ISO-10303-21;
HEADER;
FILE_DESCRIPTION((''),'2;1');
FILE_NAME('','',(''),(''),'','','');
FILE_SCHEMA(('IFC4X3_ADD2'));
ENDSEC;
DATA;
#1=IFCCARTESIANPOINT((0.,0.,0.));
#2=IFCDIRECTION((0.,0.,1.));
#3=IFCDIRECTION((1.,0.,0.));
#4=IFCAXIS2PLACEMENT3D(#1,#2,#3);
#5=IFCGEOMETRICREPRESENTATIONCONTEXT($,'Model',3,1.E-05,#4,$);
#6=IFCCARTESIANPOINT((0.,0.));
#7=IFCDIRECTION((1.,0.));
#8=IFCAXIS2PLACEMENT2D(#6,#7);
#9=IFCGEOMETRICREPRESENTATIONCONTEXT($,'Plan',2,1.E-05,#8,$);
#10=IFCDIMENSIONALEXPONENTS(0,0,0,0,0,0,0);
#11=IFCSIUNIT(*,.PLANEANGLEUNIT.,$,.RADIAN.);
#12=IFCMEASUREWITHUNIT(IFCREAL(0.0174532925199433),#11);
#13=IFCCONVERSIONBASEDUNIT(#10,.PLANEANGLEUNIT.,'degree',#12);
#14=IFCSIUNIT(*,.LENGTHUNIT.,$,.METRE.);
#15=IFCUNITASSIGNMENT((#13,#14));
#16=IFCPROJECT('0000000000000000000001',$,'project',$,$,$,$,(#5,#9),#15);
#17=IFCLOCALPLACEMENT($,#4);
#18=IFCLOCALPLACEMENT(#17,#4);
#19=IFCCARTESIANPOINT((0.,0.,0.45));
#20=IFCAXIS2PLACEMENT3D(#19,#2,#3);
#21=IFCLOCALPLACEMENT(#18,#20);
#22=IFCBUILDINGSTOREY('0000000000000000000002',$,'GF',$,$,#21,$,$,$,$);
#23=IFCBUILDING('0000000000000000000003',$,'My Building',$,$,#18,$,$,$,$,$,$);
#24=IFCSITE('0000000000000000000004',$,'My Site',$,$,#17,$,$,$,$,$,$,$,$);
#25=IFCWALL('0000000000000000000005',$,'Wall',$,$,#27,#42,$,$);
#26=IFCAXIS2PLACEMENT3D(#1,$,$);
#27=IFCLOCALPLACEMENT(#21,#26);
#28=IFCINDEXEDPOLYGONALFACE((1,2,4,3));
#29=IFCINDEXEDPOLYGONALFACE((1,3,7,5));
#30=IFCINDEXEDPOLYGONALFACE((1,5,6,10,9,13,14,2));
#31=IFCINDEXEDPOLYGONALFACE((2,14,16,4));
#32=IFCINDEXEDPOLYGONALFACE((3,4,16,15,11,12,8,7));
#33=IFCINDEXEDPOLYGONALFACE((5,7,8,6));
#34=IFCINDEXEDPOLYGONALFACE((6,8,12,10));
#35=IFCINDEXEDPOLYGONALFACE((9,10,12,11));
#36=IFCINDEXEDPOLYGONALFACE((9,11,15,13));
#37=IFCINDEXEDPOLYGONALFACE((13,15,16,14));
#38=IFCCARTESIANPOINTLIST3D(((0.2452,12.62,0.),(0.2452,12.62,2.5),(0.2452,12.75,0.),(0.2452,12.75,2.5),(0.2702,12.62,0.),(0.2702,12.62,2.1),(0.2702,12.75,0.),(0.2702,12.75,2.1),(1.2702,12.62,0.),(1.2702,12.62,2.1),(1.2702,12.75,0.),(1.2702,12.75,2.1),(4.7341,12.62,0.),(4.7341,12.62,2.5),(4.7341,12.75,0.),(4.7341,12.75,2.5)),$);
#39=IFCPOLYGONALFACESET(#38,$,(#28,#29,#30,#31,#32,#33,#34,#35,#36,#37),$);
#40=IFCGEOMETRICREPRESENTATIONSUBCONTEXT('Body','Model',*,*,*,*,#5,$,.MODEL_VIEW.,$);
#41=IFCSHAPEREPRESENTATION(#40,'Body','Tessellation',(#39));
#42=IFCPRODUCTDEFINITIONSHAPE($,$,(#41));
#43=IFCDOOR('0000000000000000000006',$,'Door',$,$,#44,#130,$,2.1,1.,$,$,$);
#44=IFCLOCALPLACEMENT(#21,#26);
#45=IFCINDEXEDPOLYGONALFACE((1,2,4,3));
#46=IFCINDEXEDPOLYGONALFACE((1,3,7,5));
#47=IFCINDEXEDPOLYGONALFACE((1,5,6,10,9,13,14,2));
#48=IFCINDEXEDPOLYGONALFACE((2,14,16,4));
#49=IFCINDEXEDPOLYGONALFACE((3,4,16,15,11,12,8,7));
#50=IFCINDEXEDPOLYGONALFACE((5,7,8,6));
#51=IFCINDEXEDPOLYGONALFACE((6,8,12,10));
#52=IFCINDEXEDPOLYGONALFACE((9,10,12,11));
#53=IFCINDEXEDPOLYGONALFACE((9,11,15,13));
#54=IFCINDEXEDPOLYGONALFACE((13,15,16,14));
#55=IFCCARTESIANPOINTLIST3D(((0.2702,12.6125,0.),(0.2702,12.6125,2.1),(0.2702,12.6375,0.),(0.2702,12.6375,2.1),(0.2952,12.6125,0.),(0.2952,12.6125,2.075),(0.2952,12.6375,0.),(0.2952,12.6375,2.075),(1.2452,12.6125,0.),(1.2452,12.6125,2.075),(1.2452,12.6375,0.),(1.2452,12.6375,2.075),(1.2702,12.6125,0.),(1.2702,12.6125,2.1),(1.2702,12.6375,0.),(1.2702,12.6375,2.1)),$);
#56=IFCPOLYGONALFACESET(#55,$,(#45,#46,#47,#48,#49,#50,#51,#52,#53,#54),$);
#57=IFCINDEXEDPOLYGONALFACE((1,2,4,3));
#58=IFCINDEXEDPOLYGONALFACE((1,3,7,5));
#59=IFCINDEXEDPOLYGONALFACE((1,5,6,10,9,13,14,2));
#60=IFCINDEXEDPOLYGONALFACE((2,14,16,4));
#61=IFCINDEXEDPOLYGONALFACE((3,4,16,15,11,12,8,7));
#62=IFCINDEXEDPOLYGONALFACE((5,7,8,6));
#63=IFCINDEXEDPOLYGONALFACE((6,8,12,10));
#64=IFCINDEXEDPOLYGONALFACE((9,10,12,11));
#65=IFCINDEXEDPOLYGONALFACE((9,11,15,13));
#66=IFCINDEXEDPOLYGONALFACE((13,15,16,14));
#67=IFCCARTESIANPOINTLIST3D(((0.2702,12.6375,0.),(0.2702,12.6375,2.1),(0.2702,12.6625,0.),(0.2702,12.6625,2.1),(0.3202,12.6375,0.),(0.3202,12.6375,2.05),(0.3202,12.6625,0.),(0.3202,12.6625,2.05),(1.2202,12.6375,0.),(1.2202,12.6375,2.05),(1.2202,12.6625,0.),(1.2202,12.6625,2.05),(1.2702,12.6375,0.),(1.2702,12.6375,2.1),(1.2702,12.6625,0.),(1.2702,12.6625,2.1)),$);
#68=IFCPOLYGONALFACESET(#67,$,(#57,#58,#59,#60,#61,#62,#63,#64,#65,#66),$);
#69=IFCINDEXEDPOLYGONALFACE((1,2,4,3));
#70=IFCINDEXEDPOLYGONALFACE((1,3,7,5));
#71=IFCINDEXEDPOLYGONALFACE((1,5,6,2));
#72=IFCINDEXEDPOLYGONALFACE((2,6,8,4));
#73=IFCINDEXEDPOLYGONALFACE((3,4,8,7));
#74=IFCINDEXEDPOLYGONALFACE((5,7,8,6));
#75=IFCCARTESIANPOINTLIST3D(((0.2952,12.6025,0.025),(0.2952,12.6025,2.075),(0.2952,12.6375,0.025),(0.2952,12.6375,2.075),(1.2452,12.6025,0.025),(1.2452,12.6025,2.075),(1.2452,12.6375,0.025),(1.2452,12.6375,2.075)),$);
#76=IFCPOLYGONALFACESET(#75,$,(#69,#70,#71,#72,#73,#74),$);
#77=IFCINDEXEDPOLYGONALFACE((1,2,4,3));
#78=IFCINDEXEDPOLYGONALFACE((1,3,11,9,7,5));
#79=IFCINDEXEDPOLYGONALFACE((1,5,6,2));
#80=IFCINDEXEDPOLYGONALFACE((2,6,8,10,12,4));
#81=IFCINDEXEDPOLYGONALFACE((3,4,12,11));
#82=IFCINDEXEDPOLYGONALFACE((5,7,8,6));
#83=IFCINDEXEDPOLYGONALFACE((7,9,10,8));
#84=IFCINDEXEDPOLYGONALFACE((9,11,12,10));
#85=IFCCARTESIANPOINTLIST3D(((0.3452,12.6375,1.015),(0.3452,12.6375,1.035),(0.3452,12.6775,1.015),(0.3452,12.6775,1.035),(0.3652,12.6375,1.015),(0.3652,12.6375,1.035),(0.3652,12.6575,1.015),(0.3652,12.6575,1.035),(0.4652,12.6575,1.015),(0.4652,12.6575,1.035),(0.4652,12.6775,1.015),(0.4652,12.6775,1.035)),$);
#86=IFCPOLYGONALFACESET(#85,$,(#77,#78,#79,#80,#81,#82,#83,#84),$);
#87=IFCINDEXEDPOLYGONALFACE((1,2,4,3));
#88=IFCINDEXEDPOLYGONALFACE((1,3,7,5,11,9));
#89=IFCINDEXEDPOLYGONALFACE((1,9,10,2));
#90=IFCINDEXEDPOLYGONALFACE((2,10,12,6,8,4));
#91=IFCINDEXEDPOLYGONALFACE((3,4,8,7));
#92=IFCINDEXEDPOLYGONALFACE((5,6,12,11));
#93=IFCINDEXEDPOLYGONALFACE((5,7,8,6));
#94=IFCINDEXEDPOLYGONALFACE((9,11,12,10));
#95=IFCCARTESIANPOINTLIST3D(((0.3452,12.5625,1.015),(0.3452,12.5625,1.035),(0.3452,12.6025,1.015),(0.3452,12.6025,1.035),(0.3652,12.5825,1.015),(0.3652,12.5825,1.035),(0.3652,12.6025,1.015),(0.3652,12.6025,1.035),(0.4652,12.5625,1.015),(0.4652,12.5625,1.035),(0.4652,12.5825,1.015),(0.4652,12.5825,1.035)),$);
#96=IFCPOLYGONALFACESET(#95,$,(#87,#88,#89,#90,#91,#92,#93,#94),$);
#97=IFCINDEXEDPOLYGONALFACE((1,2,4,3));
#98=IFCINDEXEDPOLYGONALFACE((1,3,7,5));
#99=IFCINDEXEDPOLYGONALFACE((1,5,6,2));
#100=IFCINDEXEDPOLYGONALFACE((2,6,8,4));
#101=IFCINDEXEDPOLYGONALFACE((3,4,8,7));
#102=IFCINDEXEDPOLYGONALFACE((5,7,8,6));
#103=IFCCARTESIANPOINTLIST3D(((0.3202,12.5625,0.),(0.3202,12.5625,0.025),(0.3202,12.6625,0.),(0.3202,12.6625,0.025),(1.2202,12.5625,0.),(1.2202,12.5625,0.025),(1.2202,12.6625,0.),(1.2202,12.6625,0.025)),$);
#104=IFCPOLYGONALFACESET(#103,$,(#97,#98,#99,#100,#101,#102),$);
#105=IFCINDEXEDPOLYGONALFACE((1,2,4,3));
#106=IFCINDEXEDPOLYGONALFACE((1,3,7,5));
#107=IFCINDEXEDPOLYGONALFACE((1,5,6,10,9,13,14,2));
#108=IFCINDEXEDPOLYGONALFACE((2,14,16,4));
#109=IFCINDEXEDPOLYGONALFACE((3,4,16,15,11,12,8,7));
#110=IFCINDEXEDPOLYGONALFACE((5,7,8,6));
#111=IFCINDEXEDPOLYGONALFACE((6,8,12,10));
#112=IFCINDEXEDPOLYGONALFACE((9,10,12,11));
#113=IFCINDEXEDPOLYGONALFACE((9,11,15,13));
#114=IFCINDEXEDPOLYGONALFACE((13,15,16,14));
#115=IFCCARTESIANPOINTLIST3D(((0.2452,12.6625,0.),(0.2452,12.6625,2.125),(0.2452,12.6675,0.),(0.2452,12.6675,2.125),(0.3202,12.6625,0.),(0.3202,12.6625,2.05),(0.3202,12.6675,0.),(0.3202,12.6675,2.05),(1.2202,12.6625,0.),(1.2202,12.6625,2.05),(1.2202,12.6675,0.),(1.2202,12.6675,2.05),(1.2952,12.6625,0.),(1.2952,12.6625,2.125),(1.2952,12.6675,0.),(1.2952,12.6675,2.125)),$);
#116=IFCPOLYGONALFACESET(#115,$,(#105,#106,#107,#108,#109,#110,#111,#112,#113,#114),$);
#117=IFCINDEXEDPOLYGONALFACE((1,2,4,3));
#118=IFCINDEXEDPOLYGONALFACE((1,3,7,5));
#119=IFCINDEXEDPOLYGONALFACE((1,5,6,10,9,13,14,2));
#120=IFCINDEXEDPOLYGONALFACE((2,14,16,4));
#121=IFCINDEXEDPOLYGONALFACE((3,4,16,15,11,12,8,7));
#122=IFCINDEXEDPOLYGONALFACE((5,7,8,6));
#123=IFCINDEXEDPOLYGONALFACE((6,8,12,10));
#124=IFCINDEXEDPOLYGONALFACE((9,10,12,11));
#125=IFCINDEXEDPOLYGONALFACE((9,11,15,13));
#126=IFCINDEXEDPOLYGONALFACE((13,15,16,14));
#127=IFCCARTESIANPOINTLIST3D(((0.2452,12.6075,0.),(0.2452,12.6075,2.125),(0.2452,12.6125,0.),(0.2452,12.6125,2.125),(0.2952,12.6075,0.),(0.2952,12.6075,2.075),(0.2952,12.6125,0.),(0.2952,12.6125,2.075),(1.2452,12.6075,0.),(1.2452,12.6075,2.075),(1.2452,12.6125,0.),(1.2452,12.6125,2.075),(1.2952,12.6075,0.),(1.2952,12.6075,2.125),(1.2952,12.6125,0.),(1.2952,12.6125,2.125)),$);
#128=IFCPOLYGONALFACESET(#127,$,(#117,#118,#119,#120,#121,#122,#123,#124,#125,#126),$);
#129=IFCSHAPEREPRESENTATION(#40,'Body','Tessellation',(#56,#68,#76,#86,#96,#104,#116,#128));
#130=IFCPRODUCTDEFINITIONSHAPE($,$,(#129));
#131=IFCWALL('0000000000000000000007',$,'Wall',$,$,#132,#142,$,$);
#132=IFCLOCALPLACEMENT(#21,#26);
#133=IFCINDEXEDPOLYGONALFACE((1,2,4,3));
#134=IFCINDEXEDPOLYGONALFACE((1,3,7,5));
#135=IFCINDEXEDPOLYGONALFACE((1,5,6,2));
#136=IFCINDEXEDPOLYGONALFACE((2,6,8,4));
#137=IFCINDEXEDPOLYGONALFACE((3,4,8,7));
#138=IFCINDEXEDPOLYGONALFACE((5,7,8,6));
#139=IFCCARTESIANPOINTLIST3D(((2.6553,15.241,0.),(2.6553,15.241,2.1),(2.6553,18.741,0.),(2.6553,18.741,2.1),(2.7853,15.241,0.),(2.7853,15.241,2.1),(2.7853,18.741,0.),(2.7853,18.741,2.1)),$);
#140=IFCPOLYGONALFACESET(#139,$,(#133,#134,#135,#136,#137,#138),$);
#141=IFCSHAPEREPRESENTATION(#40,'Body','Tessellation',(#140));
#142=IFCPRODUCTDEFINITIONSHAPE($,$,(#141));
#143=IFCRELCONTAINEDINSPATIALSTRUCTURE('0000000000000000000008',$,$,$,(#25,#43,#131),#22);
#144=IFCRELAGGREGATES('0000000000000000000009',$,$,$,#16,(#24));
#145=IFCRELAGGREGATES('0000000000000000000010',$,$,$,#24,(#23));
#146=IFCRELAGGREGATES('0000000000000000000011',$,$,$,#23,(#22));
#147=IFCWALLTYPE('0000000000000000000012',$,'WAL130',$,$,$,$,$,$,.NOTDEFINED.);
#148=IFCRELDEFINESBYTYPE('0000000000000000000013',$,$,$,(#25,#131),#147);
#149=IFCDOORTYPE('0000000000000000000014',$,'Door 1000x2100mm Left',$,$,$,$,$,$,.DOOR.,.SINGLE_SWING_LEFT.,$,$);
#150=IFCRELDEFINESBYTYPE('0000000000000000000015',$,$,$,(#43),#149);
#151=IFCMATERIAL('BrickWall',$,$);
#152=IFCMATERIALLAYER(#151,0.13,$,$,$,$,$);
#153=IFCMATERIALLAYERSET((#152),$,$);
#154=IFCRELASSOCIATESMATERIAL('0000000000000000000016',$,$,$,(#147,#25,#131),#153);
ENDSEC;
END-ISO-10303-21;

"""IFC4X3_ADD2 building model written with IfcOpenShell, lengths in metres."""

from ifc_helpers import new_model, entity, si_unit, converted_unit, frame, origin_with_axes, origin_2d_with_axis, place, context, subcontext, project, spatial, line, indexed_curve, outline, extrude, shape, source, transform, mapped, material, layer, layer_set, layer_usage, type_object, type_shapes, element, fill, save


model = new_model("IFC4X3_ADD2")

# Units and contexts
model_context = context("Model", 3, precision=1e-05, world=origin_with_axes())
plan_context = context("Plan", 2, precision=1e-05, world=origin_2d_with_axis())
body_context_1 = subcontext(model_context, "Body", "Model", "MODEL_VIEW")
body_context_2 = subcontext(plan_context, "Body", "Plan", "PLAN_VIEW")
ifc_project = project(units=[converted_unit("PLANEANGLEUNIT", "degree", entity("IfcReal", 0.0174532925199433), si_unit("PLANEANGLEUNIT", "RADIAN"), dimensions=[0, 0, 0, 0, 0, 0, 0]), si_unit("LENGTHUNIT", "METRE")], contexts=[model_context, plan_context])

# Site, building, storey
site_placement = place(None, origin_with_axes())
site = spatial("IfcSite", under=ifc_project, at=site_placement, Name="My Site")
building_placement = place(site_placement, origin_with_axes())
building = spatial("IfcBuilding", under=site, at=building_placement, Name="My Building")
storey_placement = place(building_placement, frame((0.0, 0.0, 0.45), z_axis=(0.0, 0.0, 1.0), x_axis=(1.0, 0.0, 0.0)))
storey = spatial("IfcBuildingStorey", under=building, at=storey_placement, Name="GF")

# Shared definitions
ifc_material_1 = material(Name="BrickWall")

# Wall, opening, door
ifc_layer_1 = layer(ifc_material_1, 0.13)
ifc_layer_set_1 = layer_set([ifc_layer_1])
ifc_layer_usage_1 = layer_usage(ifc_layer_set_1, "AXIS2", "POSITIVE", 0.0)
wall_type_1 = type_object("IfcWallType", Name="WAL130", PredefinedType="NOTDEFINED", material=ifc_layer_set_1)
wall_1_placement = place(storey_placement, frame((0.2452, 12.62, 0.0), z_axis=(0.0, 0.0, 1.0), x_axis=(1.0, 0.0, 0.0)))
wall_1 = element("IfcWall", 1, at=wall_1_placement, inside=storey, type_object=wall_type_1, material=ifc_layer_usage_1, Name="Wall", context=body_context_1, shape_type="SweptSolid", body=[
    extrude(outline(indexed_curve([(0.0, 0.0), (0.0, 0.13), (4.4889, 0.13), (4.4889, 0.0), (0.0, 0.0)], self_intersect=False)), origin_with_axes(), (0.0, 0.0, 1.0), 2.5),
])
shared_shape_1 = source(origin_with_axes(), body_context_1, "Body", "SweptSolid", [
    extrude(outline(indexed_curve([(0.0, 0.0), (1.0, 0.0), (1.0, 2.1), (0.0, 2.1)], segments=[line(1, 2, 3, 4, 1)])), frame((0.0, -0.6, 0.0), z_axis=(0.0, -1.0, 0.0), x_axis=(1.0, 0.0, 0.0)), (0.0, 0.0, -1.0), 1.2),
])
opening_1_placement = place(wall_1_placement, frame((1.025, 0.0425, 0.0), z_axis=(0.0, 0.0, 1.0), x_axis=(-1.0, 0.0, 0.0)))
opening_1 = element("IfcOpeningElement", 2, at=opening_1_placement, cuts=wall_1, PredefinedType="OPENING", context=body_context_1, shape_type="MappedRepresentation", body=[
    mapped(shared_shape_1, transform((0.0, 0.0, 0.0), x_axis=(1.0, 0.0, 0.0), y_axis=(0.0, 1.0, 0.0), z_axis=(0.0, 0.0, 1.0), scale=1.0)),
])
door_type_1 = type_object("IfcDoorType", Name="Door 1000x2100mm Left", OperationType="SINGLE_SWING_LEFT", PredefinedType="DOOR")
shared_shape_2 = source(origin_with_axes(), body_context_1, "Body", "SweptSolid", [
    extrude(outline(indexed_curve([(0.0, 0.0), (0.0, 2.1), (1.0, 2.1), (1.0, 0.0), (0.975, 0.0), (0.975, 2.075), (0.025, 2.075), (0.025, 0.0)], segments=[line(1, 2, 3, 4, 5, 6, 7, 8, 1)])), frame((0.0, 0.025, 0.0), z_axis=(0.0, -1.0, 0.0), x_axis=(1.0, 0.0, 0.0)), (0.0, 0.0, -1.0), 0.025),
    extrude(outline(indexed_curve([(0.0, 0.0), (0.0, 2.1), (1.0, 2.1), (1.0, 0.0), (0.95, 0.0), (0.95, 2.05), (0.05, 2.05), (0.05, 0.0)], segments=[line(1, 2, 3, 4, 5, 6, 7, 8, 1)])), frame((0.0, 0.0, 0.0), z_axis=(0.0, -1.0, 0.0), x_axis=(1.0, 0.0, 0.0)), (0.0, 0.0, -1.0), 0.025),
    extrude(outline(indexed_curve([(0.0, 0.0), (0.95, 0.0), (0.95, 0.035), (0.0, 0.035)], segments=[line(1, 2, 3, 4, 1)])), frame((0.025, 0.025, 0.025), z_axis=(0.0, 0.0, 1.0), x_axis=(1.0, 0.0, 0.0)), (0.0, 0.0, 1.0), 2.05),
    extrude(outline(indexed_curve([(0.0, 0.0), (0.0, -0.04), (-0.12, -0.04), (-0.12, -0.02), (-0.02, -0.02), (-0.02, 0.0)], segments=[line(1, 2, 3, 4, 5, 6, 1)])), frame((0.925, 0.025, 1.015), z_axis=(0.0, 0.0, 1.0), x_axis=(1.0, 0.0, 0.0)), (0.0, 0.0, 1.0), 0.02),
    extrude(outline(indexed_curve([(0.0, 0.0), (0.0, 0.04), (-0.12, 0.04), (-0.12, 0.02), (-0.02, 0.02), (-0.02, 0.0)], segments=[line(1, 2, 3, 4, 5, 6, 1)])), frame((0.925, 0.06, 1.015), z_axis=(0.0, 0.0, 1.0), x_axis=(1.0, 0.0, 0.0)), (0.0, 0.0, 1.0), 0.02),
    extrude(outline(indexed_curve([(0.0, 0.0), (0.9, 0.0), (0.9, 0.1), (0.0, 0.1)], segments=[line(1, 2, 3, 4, 1)])), frame((0.05, 0.0, 0.0), z_axis=(0.0, 0.0, 1.0), x_axis=(1.0, 0.0, 0.0)), (0.0, 0.0, 1.0), 0.025),
    extrude(outline(indexed_curve([(0.0, 0.0), (0.0, 2.125), (1.05, 2.125), (1.05, 0.0), (0.975, 0.0), (0.975, 2.05), (0.075, 2.05), (0.075, 0.0)], segments=[line(1, 2, 3, 4, 5, 6, 7, 8, 1)])), frame((-0.025, -0.005, 0.0), z_axis=(0.0, -1.0, 0.0), x_axis=(1.0, 0.0, 0.0)), (0.0, 0.0, -1.0), 0.005),
    extrude(outline(indexed_curve([(0.0, 0.0), (0.0, 2.125), (1.05, 2.125), (1.05, 0.0), (1.0, 0.0), (1.0, 2.075), (0.05, 2.075), (0.05, 0.0)], segments=[line(1, 2, 3, 4, 5, 6, 7, 8, 1)])), frame((-0.025, 0.05, 0.0), z_axis=(0.0, -1.0, 0.0), x_axis=(1.0, 0.0, 0.0)), (0.0, 0.0, -1.0), 0.005),
])
shared_shape_3 = source(origin_with_axes(), body_context_2, "Body", "Curve2D", [
    entity("IfcIndexedPolyCurve", entity("IfcCartesianPointList2D", [[0.0, 0.0], [0.0, 0.05], [0.025, 0.05], [0.025, 0.025], [0.05, 0.025], [0.05, 0.0]]), [entity("IfcLineIndex", [1, 2, 3, 4, 5, 6, 1])]),
    entity("IfcIndexedPolyCurve", entity("IfcCartesianPointList2D", [[1.0, 0.0], [1.0, 0.05], [0.975, 0.05], [0.975, 0.025], [0.95, 0.025], [0.95, 0.0]]), [entity("IfcLineIndex", [1, 2, 3, 4, 5, 6, 1])]),
    entity("IfcTrimmedCurve", entity("IfcEllipse", entity("IfcAxis2Placement2D", entity("IfcCartesianPoint", [0.06, 0.05]), entity("IfcDirection", [1.0, 0.0])), 0.915, 0.95), [entity("IfcCartesianPoint", [0.975, 0.05])], [entity("IfcCartesianPoint", [0.06, 1.0])], True, "CARTESIAN"),
    entity("IfcIndexedPolyCurve", entity("IfcCartesianPointList2D", [[0.025, 0.05], [0.06, 0.05], [0.06, 1.0], [0.025, 1.0]]), [entity("IfcLineIndex", [1, 2, 3, 4, 1])]),
])
type_shapes(door_type_1, [shared_shape_2, shared_shape_3])
door_1_placement = place(opening_1_placement, frame((0.0, 0.0, 0.0), z_axis=(0.0, 0.0, 1.0), x_axis=(1.0, 0.0, 0.0)))
door_1 = element("IfcDoor", 3, at=door_1_placement, inside=storey, type_object=door_type_1, Name="Door", OverallHeight=2.1, OverallWidth=1.0, shapes=[
    shape(body_context_1, "Body", "MappedRepresentation", [mapped(shared_shape_2, transform((0.0, 0.0, 0.0), x_axis=(1.0, 0.0, 0.0), y_axis=(0.0, 1.0, 0.0), z_axis=(0.0, 0.0, 1.0), scale=1.0))]),
    shape(body_context_2, "Body", "MappedRepresentation", [mapped(shared_shape_3, transform((0.0, 0.0, 0.0), x_axis=(1.0, 0.0, 0.0), y_axis=(0.0, 1.0, 0.0), z_axis=(0.0, 0.0, 1.0), scale=1.0))]),
])
fill(opening_1, door_1)

# Wall
ifc_layer_usage_2 = layer_usage(ifc_layer_set_1, "AXIS2", "POSITIVE", 0.0)
wall_2_placement = place(storey_placement, frame((2.7853, 15.241, 0.0), z_axis=(0.0, 0.0, 1.0), x_axis=(0.0, 1.0, 0.0)))
element("IfcWall", 4, at=wall_2_placement, inside=storey, type_object=wall_type_1, material=ifc_layer_usage_2, Name="Wall", context=body_context_1, shape_type="SweptSolid", body=[
    extrude(outline(indexed_curve([(0.0, 0.0), (0.0, 0.13), (3.5, 0.13), (3.5, 0.0), (0.0, 0.0)], self_intersect=False)), origin_with_axes(), (0.0, 0.0, 1.0), 2.1),
])

save(model, "model.ifc")
